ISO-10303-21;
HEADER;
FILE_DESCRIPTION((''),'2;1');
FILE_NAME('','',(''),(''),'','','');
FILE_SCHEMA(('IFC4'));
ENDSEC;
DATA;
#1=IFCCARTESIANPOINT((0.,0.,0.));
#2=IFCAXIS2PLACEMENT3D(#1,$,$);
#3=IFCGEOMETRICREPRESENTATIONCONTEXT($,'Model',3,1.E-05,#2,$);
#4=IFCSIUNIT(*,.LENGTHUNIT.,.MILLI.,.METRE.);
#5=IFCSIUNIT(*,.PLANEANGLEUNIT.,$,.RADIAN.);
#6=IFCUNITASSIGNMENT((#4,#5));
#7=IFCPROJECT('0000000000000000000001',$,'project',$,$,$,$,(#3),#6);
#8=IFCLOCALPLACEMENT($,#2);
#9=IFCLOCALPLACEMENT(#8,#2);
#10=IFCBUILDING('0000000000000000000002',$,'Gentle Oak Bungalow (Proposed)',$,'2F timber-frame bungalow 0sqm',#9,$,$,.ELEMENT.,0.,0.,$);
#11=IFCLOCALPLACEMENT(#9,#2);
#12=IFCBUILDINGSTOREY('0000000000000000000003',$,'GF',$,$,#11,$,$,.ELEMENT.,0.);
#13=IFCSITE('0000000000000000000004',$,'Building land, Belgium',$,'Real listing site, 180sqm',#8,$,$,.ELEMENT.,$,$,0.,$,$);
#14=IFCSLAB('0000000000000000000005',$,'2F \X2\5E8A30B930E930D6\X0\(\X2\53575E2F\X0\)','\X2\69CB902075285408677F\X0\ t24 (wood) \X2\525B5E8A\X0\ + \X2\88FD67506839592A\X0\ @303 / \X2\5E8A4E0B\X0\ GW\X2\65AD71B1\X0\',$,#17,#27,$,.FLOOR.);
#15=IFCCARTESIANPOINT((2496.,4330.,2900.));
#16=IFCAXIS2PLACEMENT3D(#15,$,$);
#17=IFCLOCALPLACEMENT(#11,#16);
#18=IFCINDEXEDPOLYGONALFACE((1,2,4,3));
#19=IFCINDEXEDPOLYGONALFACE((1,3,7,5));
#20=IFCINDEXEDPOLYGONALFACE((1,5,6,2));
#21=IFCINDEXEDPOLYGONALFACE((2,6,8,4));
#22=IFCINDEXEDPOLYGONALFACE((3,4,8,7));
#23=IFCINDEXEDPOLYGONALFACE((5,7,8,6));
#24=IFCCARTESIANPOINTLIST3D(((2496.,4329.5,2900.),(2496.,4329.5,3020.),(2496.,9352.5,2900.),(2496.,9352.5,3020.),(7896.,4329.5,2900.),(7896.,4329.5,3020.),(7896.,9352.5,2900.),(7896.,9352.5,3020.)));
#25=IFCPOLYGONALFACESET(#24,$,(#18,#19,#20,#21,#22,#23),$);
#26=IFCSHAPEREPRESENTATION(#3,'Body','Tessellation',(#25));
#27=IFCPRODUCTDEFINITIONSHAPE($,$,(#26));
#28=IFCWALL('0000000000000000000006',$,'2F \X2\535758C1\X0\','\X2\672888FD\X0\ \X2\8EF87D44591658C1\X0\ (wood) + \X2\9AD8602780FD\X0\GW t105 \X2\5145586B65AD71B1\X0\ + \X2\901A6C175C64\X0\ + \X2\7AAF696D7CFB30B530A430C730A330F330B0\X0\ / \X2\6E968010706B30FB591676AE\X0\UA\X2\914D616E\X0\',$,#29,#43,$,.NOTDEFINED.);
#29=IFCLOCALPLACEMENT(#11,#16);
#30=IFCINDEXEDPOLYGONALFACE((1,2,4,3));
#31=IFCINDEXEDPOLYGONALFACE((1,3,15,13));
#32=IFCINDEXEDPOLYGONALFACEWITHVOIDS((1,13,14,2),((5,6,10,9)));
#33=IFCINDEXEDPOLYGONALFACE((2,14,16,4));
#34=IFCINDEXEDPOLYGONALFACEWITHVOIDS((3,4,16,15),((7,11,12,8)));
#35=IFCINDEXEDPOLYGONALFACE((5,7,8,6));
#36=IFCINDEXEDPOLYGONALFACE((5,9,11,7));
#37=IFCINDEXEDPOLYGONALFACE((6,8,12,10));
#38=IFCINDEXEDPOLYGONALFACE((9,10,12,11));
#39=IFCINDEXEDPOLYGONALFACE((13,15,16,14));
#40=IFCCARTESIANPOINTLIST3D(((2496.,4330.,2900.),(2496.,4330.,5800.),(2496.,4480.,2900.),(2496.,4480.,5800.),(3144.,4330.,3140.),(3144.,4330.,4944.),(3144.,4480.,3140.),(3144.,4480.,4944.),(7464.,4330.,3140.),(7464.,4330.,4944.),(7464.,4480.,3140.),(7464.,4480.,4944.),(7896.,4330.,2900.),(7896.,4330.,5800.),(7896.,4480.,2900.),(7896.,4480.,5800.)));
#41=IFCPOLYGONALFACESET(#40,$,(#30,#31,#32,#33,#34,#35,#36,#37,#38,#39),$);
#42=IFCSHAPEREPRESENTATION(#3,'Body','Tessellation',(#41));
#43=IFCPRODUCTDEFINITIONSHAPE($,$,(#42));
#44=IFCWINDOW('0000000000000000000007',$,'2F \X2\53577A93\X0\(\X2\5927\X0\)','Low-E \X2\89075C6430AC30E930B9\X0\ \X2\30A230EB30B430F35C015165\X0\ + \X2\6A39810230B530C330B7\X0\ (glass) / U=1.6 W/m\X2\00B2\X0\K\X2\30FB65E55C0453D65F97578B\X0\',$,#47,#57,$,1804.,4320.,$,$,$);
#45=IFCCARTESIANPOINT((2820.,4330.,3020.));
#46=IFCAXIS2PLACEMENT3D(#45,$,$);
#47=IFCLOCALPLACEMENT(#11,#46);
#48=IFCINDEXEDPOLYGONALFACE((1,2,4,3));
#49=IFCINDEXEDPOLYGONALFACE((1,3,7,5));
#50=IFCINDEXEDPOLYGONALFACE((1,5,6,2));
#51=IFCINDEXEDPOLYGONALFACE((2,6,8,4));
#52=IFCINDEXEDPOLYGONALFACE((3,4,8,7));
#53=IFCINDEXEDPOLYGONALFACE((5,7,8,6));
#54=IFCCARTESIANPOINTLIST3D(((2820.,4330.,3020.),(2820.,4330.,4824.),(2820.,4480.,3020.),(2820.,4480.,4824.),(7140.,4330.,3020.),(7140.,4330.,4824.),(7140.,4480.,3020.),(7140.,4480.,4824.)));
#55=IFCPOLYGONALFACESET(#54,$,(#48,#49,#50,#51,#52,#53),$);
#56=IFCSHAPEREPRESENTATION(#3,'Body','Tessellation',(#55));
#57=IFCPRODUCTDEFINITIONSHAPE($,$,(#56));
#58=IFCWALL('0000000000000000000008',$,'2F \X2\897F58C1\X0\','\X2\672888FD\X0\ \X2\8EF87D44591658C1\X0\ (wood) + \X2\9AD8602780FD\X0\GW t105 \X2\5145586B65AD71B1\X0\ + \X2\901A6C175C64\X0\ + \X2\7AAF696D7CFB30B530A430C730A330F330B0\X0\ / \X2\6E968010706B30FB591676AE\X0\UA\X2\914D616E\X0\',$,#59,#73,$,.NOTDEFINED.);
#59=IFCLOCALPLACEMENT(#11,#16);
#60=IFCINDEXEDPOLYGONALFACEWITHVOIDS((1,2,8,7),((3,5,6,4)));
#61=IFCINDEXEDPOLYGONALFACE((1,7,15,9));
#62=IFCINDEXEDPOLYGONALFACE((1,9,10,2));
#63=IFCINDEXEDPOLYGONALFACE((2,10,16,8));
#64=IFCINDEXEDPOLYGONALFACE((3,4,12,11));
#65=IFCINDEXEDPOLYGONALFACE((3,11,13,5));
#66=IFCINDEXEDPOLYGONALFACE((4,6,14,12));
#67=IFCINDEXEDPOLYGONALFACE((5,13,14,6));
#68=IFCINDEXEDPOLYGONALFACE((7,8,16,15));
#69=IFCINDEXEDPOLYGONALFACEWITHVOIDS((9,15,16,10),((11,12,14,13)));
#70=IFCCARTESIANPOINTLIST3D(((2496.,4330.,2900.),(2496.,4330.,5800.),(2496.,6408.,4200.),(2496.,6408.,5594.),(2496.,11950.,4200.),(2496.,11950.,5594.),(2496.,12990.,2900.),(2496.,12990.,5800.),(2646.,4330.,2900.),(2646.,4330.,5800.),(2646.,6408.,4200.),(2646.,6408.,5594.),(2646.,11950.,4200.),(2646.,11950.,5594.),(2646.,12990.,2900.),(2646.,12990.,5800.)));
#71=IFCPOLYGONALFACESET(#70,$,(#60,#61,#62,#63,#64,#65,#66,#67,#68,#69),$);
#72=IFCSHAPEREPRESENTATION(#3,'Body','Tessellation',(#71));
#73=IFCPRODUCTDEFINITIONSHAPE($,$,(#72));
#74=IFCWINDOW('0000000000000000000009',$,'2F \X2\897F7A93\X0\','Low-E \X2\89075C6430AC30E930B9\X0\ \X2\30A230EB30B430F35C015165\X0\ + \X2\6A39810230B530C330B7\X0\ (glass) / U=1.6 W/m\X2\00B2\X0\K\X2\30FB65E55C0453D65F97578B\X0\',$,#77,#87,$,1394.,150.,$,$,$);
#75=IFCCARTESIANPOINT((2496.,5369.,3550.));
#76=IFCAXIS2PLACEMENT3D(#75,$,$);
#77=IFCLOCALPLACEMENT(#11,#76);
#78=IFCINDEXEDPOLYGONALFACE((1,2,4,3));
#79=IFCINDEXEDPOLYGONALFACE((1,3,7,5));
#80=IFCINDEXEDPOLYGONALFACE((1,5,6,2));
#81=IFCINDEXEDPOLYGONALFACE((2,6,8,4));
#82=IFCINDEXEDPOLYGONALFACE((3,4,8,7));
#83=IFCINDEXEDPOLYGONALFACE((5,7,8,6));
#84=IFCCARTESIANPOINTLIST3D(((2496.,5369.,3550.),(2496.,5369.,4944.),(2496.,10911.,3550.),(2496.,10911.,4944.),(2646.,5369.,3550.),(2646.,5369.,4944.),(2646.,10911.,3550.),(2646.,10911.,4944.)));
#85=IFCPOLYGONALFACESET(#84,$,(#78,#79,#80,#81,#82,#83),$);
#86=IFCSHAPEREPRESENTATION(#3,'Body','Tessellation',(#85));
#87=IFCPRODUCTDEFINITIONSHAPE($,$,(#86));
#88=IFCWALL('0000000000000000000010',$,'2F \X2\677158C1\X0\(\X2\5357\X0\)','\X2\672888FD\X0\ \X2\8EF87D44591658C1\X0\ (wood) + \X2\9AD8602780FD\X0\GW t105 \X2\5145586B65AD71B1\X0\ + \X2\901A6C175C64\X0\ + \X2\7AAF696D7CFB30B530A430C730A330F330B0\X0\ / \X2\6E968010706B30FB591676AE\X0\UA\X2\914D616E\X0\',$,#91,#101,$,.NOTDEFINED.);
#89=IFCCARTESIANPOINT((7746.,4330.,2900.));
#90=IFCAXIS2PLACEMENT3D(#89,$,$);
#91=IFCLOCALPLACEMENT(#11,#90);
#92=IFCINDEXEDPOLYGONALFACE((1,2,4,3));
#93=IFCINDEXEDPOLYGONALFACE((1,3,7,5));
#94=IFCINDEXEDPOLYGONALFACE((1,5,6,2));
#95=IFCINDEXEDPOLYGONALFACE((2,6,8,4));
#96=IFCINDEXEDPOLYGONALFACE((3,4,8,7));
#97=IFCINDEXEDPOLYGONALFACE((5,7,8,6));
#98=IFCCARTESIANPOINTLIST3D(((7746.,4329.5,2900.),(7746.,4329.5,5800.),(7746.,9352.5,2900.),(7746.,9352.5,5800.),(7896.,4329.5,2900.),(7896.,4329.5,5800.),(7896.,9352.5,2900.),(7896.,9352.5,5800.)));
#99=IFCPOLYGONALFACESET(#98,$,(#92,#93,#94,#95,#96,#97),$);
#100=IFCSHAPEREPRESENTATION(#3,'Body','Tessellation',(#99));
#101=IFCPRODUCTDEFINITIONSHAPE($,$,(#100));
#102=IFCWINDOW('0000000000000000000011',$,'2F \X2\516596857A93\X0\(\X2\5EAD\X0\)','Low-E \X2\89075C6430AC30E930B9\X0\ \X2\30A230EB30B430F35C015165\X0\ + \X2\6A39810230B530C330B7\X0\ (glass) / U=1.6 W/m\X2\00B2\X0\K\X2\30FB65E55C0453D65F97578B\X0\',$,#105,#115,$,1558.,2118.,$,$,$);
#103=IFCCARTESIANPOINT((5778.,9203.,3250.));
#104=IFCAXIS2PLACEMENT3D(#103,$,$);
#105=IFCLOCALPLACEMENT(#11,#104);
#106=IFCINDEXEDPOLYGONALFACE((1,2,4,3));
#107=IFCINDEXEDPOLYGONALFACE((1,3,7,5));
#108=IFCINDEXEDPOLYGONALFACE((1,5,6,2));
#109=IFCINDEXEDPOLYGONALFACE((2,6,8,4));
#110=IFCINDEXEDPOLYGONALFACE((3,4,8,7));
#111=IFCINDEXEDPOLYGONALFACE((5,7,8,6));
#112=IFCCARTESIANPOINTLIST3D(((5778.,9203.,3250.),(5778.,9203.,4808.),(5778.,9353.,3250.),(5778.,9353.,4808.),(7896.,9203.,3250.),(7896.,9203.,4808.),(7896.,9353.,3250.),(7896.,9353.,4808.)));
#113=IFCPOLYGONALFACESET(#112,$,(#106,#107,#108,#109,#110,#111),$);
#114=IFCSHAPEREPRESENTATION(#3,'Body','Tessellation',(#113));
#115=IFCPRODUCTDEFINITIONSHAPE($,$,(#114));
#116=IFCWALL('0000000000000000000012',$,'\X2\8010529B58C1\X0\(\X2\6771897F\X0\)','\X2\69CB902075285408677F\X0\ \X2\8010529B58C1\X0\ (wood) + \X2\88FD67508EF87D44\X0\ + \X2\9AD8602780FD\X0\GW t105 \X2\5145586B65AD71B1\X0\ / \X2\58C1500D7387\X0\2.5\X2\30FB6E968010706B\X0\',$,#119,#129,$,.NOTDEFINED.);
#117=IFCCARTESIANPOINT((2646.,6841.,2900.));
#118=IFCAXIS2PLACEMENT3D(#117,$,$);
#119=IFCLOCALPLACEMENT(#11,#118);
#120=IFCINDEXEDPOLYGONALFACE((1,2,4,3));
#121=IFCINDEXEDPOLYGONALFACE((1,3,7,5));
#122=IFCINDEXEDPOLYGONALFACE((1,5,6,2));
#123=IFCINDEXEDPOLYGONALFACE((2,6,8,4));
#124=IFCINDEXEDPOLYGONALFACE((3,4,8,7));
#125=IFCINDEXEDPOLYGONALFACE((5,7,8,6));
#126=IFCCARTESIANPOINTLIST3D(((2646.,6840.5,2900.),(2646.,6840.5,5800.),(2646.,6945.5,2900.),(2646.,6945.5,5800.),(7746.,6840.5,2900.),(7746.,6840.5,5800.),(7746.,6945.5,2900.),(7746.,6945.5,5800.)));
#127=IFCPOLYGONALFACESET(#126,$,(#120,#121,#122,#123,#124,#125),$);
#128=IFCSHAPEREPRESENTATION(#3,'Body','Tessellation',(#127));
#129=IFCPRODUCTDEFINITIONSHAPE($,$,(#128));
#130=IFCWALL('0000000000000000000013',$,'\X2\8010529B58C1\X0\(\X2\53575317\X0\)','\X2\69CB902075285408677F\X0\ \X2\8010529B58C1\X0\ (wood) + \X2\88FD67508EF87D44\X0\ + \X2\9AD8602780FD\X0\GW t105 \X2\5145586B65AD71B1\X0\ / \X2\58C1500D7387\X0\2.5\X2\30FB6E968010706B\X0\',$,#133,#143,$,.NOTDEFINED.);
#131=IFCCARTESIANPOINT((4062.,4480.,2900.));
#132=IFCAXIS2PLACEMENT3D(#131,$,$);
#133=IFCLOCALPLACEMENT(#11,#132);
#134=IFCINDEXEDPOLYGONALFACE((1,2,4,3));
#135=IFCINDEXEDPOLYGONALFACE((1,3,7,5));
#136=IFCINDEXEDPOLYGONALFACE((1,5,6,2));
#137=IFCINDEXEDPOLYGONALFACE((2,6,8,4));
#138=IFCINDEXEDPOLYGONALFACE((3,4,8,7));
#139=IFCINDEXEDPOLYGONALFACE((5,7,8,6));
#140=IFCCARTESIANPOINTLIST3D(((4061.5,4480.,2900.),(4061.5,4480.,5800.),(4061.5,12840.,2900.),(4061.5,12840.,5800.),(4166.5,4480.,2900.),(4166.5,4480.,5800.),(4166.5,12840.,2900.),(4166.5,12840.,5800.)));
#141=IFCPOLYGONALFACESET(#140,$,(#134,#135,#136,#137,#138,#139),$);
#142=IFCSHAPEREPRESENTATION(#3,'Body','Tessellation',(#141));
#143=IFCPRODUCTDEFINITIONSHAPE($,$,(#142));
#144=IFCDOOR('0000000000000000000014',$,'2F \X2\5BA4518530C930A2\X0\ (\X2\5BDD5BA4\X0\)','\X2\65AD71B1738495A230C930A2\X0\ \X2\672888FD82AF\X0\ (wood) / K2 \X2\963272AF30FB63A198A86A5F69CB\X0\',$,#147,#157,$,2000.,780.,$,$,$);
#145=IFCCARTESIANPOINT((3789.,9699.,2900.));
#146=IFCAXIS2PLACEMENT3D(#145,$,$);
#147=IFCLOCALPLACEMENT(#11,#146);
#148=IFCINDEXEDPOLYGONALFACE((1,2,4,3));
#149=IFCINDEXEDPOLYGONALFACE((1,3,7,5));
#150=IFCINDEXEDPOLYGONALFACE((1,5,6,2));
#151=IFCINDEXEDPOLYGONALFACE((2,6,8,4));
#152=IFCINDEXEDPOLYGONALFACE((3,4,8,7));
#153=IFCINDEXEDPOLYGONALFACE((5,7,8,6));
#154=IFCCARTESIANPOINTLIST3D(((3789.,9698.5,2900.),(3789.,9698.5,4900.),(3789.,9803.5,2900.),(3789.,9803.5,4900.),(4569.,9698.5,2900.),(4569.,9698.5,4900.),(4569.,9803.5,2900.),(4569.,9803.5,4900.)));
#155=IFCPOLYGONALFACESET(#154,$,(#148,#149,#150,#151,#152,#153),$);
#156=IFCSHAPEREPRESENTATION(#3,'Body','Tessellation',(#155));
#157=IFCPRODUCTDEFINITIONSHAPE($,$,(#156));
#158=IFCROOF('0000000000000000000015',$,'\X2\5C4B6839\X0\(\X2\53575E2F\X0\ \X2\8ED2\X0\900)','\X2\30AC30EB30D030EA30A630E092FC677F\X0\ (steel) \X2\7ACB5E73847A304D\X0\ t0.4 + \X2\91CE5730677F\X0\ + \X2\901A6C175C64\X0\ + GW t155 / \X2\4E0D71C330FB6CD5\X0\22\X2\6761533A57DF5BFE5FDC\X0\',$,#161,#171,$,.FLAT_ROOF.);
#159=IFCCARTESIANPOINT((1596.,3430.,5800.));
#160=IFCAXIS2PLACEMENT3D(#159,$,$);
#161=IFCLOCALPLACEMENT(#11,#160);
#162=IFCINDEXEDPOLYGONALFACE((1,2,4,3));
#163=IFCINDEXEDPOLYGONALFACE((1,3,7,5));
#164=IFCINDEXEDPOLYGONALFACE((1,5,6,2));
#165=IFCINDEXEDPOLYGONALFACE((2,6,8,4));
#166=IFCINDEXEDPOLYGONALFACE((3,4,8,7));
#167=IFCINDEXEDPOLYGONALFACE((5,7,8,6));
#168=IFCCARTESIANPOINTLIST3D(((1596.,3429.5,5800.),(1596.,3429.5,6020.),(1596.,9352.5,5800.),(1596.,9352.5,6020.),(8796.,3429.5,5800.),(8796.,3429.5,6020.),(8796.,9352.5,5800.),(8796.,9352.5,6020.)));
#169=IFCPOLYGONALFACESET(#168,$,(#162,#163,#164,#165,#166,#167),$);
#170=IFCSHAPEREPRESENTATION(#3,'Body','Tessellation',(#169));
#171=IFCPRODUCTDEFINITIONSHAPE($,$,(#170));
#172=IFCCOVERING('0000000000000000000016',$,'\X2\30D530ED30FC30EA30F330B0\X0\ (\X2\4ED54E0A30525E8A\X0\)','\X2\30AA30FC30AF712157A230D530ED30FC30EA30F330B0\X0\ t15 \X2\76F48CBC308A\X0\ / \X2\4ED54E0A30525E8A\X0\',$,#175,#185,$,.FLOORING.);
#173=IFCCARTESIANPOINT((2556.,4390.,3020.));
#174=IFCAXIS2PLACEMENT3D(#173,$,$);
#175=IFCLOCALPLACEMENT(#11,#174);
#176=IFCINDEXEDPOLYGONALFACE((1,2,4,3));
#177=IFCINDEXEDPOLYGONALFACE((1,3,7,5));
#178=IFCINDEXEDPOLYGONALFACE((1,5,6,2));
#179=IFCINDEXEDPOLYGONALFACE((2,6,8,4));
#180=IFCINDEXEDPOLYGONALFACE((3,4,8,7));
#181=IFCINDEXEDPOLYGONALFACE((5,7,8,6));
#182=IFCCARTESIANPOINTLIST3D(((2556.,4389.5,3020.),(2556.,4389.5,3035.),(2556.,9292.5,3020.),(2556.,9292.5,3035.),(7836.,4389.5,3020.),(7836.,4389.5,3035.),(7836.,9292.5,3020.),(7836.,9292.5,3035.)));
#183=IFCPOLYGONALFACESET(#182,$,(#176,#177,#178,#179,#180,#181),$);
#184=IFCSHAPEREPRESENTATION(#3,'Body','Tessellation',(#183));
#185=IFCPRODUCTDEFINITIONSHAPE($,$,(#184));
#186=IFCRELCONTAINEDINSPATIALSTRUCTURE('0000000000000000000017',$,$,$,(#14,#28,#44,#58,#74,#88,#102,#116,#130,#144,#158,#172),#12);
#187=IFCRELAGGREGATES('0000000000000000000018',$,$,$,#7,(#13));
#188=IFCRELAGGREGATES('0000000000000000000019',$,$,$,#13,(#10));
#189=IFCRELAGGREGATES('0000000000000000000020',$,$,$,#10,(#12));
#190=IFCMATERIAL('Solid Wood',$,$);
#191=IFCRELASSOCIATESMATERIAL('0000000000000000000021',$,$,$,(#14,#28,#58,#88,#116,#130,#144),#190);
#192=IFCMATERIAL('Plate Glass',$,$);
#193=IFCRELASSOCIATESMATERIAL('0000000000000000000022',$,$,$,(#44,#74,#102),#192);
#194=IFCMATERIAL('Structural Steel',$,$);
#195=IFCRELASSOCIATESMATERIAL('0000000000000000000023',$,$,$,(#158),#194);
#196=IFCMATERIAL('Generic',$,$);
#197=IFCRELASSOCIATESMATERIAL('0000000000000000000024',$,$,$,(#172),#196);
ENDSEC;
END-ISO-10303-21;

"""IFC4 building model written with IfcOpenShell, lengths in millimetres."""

from ifc_helpers import new_model, si_unit, frame, frame_2d, origin, place, context, project, spatial, rectangle, extrude, material, element, fill, save


model = new_model("IFC4")

# Units and contexts
model_context = context("Model", 3, precision=1e-05, world=origin())
ifc_project = project(units=[si_unit("LENGTHUNIT", "METRE", prefix="MILLI"), si_unit("PLANEANGLEUNIT", "RADIAN")], contexts=[model_context])

# Site, building, storey
site_placement = place(None, origin())
site = spatial("IfcSite", under=ifc_project, at=site_placement, Name="Building land, Belgium", ObjectType="Real listing site, 180sqm", CompositionType="ELEMENT", RefElevation=0.0)
building_placement = place(site_placement, origin())
building = spatial("IfcBuilding", under=site, at=building_placement, Name="Gentle Oak Bungalow (Proposed)", ObjectType="2F timber-frame bungalow 0sqm", CompositionType="ELEMENT", ElevationOfRefHeight=0.0, ElevationOfTerrain=0.0)
storey_placement = place(building_placement, origin())
storey = spatial("IfcBuildingStorey", under=building, at=storey_placement, Name="GF", CompositionType="ELEMENT", Elevation=0.0)

# Slab
ifc_material_1 = material(Name="Solid Wood")
slab_placement = place(storey_placement, frame((2496.0, 4330.0, 2900.0)))
element("IfcSlab", 1, at=slab_placement, inside=storey, material=ifc_material_1, Name="2F 床スラブ(南帯)", Description="構造用合板 t24 (wood) 剛床 + 製材根太 @303 / 床下 GW断熱", PredefinedType="FLOOR", context=model_context, shape_type="SweptSolid", body=[
    extrude(rectangle(XDim=5400.0, YDim=5023.0, at=frame_2d((2700.0, 2511.0))), frame((2496.0, 4330.0, 2900.0)), (0.0, 0.0, 1.0), 120.0),
])

# Walls, openings, windows
wall_1_placement = place(storey_placement, frame((2496.0, 4330.0, 2900.0)))
wall_1 = element("IfcWall", 2, at=wall_1_placement, inside=storey, material=ifc_material_1, Name="2F 南壁", Description="木製 軸組外壁 (wood) + 高性能GW t105 充填断熱 + 通気層 + 窯業系サイディング / 準耐火・外皮UA配慮", PredefinedType="NOTDEFINED", context=model_context, shape_type="SweptSolid", body=[
    extrude(rectangle(XDim=5400.0, YDim=150.0, at=frame_2d((2700.0, 75.0))), frame((2496.0, 4330.0, 2900.0)), (0.0, 0.0, 1.0), 2900.0),
])
opening_1_placement = place(storey_placement, frame((2820.0, 4330.0, 3020.0)))
opening_1 = element("IfcOpeningElement", 3, at=opening_1_placement, cuts=wall_1, PredefinedType="NOTDEFINED", context=model_context, shape_type="SweptSolid", body=[
    extrude(rectangle(XDim=4320.0, YDim=150.0, at=frame_2d((2160.0, 75.0))), frame((2820.0, 4330.0, 3020.0)), (0.0, 0.0, 1.0), 1804.0),
])
ifc_material_2 = material(Name="Plate Glass")
window_1_placement = place(storey_placement, frame((2820.0, 4330.0, 3020.0)))
window_1 = element("IfcWindow", 4, at=window_1_placement, inside=storey, material=ifc_material_2, Name="2F 南窓(大)", Description="Low-E 複層ガラス アルゴン封入 + 樹脂サッシ (glass) / U=1.6 W/m²K・日射取得型", OverallHeight=1804.0, OverallWidth=4320.0, context=model_context, shape_type="SweptSolid", body=[
    extrude(rectangle(XDim=4320.0, YDim=150.0, at=frame_2d((2160.0, 75.0))), frame((2820.0, 4330.0, 3020.0)), (0.0, 0.0, 1.0), 1804.0),
])
fill(opening_1, window_1)
wall_2_placement = place(storey_placement, frame((2496.0, 4330.0, 2900.0)))
wall_2 = element("IfcWall", 5, at=wall_2_placement, inside=storey, material=ifc_material_1, Name="2F 西壁", Description="木製 軸組外壁 (wood) + 高性能GW t105 充填断熱 + 通気層 + 窯業系サイディング / 準耐火・外皮UA配慮", PredefinedType="NOTDEFINED", context=model_context, shape_type="SweptSolid", body=[
    extrude(rectangle(XDim=150.0, YDim=8660.0, at=frame_2d((75.0, 4330.0))), frame((2496.0, 4330.0, 2900.0)), (0.0, 0.0, 1.0), 2900.0),
])
opening_2_placement = place(storey_placement, frame((2496.0, 5369.0, 3550.0)))
opening_2 = element("IfcOpeningElement", 6, at=opening_2_placement, cuts=wall_2, PredefinedType="NOTDEFINED", context=model_context, shape_type="SweptSolid", body=[
    extrude(rectangle(XDim=150.0, YDim=5542.0, at=frame_2d((75.0, 2771.0))), frame((2496.0, 5369.0, 3550.0)), (0.0, 0.0, 1.0), 1394.0),
])
window_2_placement = place(storey_placement, frame((2496.0, 5369.0, 3550.0)))
window_2 = element("IfcWindow", 7, at=window_2_placement, inside=storey, material=ifc_material_2, Name="2F 西窓", Description="Low-E 複層ガラス アルゴン封入 + 樹脂サッシ (glass) / U=1.6 W/m²K・日射取得型", OverallHeight=1394.0, OverallWidth=150.0, context=model_context, shape_type="SweptSolid", body=[
    extrude(rectangle(XDim=150.0, YDim=5542.0, at=frame_2d((75.0, 2771.0))), frame((2496.0, 5369.0, 3550.0)), (0.0, 0.0, 1.0), 1394.0),
])
fill(opening_2, window_2)
wall_3_placement = place(storey_placement, frame((7746.0, 4330.0, 2900.0)))
wall_3 = element("IfcWall", 8, at=wall_3_placement, inside=storey, material=ifc_material_1, Name="2F 東壁(南)", Description="木製 軸組外壁 (wood) + 高性能GW t105 充填断熱 + 通気層 + 窯業系サイディング / 準耐火・外皮UA配慮", PredefinedType="NOTDEFINED", context=model_context, shape_type="SweptSolid", body=[
    extrude(rectangle(XDim=150.0, YDim=5023.0, at=frame_2d((75.0, 2511.0))), frame((7746.0, 4330.0, 2900.0)), (0.0, 0.0, 1.0), 2900.0),
])
opening_3_placement = place(storey_placement, frame((5778.0, 9203.0, 3250.0)))
opening_3 = element("IfcOpeningElement", 9, at=opening_3_placement, cuts=wall_3, PredefinedType="NOTDEFINED", context=model_context, shape_type="SweptSolid", body=[
    extrude(rectangle(XDim=2118.0, YDim=150.0, at=frame_2d((1059.0, 75.0))), frame((5778.0, 9203.0, 3250.0)), (0.0, 0.0, 1.0), 1558.0),
])
window_3_placement = place(storey_placement, frame((5778.0, 9203.0, 3250.0)))
window_3 = element("IfcWindow", 10, at=window_3_placement, inside=storey, material=ifc_material_2, Name="2F 入隅窓(庭)", Description="Low-E 複層ガラス アルゴン封入 + 樹脂サッシ (glass) / U=1.6 W/m²K・日射取得型", OverallHeight=1558.0, OverallWidth=2118.0, context=model_context, shape_type="SweptSolid", body=[
    extrude(rectangle(XDim=2118.0, YDim=150.0, at=frame_2d((1059.0, 75.0))), frame((5778.0, 9203.0, 3250.0)), (0.0, 0.0, 1.0), 1558.0),
])
fill(opening_3, window_3)

# Wall
wall_4_placement = place(storey_placement, frame((2646.0, 6841.0, 2900.0)))
element("IfcWall", 11, at=wall_4_placement, inside=storey, material=ifc_material_1, Name="耐力壁(東西)", Description="構造用合板 耐力壁 (wood) + 製材軸組 + 高性能GW t105 充填断熱 / 壁倍率2.5・準耐火", PredefinedType="NOTDEFINED", context=model_context, shape_type="SweptSolid", body=[
    extrude(rectangle(XDim=5100.0, YDim=105.0, at=frame_2d((2550.0, 52.0))), frame((2646.0, 6841.0, 2900.0)), (0.0, 0.0, 1.0), 2900.0),
])

# Wall, opening, door
wall_5_placement = place(storey_placement, frame((4062.0, 4480.0, 2900.0)))
wall_5 = element("IfcWall", 12, at=wall_5_placement, inside=storey, material=ifc_material_1, Name="耐力壁(南北)", Description="構造用合板 耐力壁 (wood) + 製材軸組 + 高性能GW t105 充填断熱 / 壁倍率2.5・準耐火", PredefinedType="NOTDEFINED", context=model_context, shape_type="SweptSolid", body=[
    extrude(rectangle(XDim=105.0, YDim=8360.0, at=frame_2d((52.0, 4180.0))), frame((4062.0, 4480.0, 2900.0)), (0.0, 0.0, 1.0), 2900.0),
])
opening_4_placement = place(storey_placement, frame((3789.0, 9699.0, 2900.0)))
opening_4 = element("IfcOpeningElement", 13, at=opening_4_placement, cuts=wall_5, PredefinedType="NOTDEFINED", context=model_context, shape_type="SweptSolid", body=[
    extrude(rectangle(XDim=780.0, YDim=105.0, at=frame_2d((390.0, 52.0))), frame((3789.0, 9699.0, 2900.0)), (0.0, 0.0, 1.0), 2000.0),
])
door_placement = place(storey_placement, frame((3789.0, 9699.0, 2900.0)))
door = element("IfcDoor", 14, at=door_placement, inside=storey, material=ifc_material_1, Name="2F 室内ドア (寝室)", Description="断熱玄関ドア 木製芯 (wood) / K2 防犯・採風機構", OverallHeight=2000.0, OverallWidth=780.0, context=model_context, shape_type="SweptSolid", body=[
    extrude(rectangle(XDim=780.0, YDim=105.0, at=frame_2d((390.0, 52.0))), frame((3789.0, 9699.0, 2900.0)), (0.0, 0.0, 1.0), 2000.0),
])
fill(opening_4, door)

# Roof
ifc_material_3 = material(Name="Structural Steel")
for number, where, name in (
    (15, (1596.0, 3430.0, 5800.0), "屋根(南帯 軒900)"),
):
    element("IfcRoof", number, at=place(storey_placement, frame(where)), inside=storey, material=ifc_material_3, Name=name, Description="ガルバリウム鋼板 (steel) 立平葺き t0.4 + 野地板 + 通気層 + GW t155 / 不燃・法22条区域対応", PredefinedType="FLAT_ROOF", context=model_context, shape_type="SweptSolid", body=[
        extrude(rectangle(XDim=7200.0, YDim=5923.0, at=frame_2d((3600.0, 2961.0))), frame((1596.0, 3430.0, 5800.0)), (0.0, 0.0, 1.0), 220.0),
    ])

# Covering
ifc_material_4 = material(Name="Generic")
covering_placement = place(storey_placement, frame((2556.0, 4390.0, 3020.0)))
element("IfcCovering", 16, at=covering_placement, inside=storey, material=ifc_material_4, Name="フローリング (仕上げ床)", Description="オーク無垢フローリング t15 直貼り / 仕上げ床", PredefinedType="FLOORING", context=model_context, shape_type="SweptSolid", body=[
    extrude(rectangle(XDim=5280.0, YDim=4903.0, at=frame_2d((2640.0, 2451.0))), frame((2556.0, 4390.0, 3020.0)), (0.0, 0.0, 1.0), 15.0),
])

save(model, "model.ifc")
